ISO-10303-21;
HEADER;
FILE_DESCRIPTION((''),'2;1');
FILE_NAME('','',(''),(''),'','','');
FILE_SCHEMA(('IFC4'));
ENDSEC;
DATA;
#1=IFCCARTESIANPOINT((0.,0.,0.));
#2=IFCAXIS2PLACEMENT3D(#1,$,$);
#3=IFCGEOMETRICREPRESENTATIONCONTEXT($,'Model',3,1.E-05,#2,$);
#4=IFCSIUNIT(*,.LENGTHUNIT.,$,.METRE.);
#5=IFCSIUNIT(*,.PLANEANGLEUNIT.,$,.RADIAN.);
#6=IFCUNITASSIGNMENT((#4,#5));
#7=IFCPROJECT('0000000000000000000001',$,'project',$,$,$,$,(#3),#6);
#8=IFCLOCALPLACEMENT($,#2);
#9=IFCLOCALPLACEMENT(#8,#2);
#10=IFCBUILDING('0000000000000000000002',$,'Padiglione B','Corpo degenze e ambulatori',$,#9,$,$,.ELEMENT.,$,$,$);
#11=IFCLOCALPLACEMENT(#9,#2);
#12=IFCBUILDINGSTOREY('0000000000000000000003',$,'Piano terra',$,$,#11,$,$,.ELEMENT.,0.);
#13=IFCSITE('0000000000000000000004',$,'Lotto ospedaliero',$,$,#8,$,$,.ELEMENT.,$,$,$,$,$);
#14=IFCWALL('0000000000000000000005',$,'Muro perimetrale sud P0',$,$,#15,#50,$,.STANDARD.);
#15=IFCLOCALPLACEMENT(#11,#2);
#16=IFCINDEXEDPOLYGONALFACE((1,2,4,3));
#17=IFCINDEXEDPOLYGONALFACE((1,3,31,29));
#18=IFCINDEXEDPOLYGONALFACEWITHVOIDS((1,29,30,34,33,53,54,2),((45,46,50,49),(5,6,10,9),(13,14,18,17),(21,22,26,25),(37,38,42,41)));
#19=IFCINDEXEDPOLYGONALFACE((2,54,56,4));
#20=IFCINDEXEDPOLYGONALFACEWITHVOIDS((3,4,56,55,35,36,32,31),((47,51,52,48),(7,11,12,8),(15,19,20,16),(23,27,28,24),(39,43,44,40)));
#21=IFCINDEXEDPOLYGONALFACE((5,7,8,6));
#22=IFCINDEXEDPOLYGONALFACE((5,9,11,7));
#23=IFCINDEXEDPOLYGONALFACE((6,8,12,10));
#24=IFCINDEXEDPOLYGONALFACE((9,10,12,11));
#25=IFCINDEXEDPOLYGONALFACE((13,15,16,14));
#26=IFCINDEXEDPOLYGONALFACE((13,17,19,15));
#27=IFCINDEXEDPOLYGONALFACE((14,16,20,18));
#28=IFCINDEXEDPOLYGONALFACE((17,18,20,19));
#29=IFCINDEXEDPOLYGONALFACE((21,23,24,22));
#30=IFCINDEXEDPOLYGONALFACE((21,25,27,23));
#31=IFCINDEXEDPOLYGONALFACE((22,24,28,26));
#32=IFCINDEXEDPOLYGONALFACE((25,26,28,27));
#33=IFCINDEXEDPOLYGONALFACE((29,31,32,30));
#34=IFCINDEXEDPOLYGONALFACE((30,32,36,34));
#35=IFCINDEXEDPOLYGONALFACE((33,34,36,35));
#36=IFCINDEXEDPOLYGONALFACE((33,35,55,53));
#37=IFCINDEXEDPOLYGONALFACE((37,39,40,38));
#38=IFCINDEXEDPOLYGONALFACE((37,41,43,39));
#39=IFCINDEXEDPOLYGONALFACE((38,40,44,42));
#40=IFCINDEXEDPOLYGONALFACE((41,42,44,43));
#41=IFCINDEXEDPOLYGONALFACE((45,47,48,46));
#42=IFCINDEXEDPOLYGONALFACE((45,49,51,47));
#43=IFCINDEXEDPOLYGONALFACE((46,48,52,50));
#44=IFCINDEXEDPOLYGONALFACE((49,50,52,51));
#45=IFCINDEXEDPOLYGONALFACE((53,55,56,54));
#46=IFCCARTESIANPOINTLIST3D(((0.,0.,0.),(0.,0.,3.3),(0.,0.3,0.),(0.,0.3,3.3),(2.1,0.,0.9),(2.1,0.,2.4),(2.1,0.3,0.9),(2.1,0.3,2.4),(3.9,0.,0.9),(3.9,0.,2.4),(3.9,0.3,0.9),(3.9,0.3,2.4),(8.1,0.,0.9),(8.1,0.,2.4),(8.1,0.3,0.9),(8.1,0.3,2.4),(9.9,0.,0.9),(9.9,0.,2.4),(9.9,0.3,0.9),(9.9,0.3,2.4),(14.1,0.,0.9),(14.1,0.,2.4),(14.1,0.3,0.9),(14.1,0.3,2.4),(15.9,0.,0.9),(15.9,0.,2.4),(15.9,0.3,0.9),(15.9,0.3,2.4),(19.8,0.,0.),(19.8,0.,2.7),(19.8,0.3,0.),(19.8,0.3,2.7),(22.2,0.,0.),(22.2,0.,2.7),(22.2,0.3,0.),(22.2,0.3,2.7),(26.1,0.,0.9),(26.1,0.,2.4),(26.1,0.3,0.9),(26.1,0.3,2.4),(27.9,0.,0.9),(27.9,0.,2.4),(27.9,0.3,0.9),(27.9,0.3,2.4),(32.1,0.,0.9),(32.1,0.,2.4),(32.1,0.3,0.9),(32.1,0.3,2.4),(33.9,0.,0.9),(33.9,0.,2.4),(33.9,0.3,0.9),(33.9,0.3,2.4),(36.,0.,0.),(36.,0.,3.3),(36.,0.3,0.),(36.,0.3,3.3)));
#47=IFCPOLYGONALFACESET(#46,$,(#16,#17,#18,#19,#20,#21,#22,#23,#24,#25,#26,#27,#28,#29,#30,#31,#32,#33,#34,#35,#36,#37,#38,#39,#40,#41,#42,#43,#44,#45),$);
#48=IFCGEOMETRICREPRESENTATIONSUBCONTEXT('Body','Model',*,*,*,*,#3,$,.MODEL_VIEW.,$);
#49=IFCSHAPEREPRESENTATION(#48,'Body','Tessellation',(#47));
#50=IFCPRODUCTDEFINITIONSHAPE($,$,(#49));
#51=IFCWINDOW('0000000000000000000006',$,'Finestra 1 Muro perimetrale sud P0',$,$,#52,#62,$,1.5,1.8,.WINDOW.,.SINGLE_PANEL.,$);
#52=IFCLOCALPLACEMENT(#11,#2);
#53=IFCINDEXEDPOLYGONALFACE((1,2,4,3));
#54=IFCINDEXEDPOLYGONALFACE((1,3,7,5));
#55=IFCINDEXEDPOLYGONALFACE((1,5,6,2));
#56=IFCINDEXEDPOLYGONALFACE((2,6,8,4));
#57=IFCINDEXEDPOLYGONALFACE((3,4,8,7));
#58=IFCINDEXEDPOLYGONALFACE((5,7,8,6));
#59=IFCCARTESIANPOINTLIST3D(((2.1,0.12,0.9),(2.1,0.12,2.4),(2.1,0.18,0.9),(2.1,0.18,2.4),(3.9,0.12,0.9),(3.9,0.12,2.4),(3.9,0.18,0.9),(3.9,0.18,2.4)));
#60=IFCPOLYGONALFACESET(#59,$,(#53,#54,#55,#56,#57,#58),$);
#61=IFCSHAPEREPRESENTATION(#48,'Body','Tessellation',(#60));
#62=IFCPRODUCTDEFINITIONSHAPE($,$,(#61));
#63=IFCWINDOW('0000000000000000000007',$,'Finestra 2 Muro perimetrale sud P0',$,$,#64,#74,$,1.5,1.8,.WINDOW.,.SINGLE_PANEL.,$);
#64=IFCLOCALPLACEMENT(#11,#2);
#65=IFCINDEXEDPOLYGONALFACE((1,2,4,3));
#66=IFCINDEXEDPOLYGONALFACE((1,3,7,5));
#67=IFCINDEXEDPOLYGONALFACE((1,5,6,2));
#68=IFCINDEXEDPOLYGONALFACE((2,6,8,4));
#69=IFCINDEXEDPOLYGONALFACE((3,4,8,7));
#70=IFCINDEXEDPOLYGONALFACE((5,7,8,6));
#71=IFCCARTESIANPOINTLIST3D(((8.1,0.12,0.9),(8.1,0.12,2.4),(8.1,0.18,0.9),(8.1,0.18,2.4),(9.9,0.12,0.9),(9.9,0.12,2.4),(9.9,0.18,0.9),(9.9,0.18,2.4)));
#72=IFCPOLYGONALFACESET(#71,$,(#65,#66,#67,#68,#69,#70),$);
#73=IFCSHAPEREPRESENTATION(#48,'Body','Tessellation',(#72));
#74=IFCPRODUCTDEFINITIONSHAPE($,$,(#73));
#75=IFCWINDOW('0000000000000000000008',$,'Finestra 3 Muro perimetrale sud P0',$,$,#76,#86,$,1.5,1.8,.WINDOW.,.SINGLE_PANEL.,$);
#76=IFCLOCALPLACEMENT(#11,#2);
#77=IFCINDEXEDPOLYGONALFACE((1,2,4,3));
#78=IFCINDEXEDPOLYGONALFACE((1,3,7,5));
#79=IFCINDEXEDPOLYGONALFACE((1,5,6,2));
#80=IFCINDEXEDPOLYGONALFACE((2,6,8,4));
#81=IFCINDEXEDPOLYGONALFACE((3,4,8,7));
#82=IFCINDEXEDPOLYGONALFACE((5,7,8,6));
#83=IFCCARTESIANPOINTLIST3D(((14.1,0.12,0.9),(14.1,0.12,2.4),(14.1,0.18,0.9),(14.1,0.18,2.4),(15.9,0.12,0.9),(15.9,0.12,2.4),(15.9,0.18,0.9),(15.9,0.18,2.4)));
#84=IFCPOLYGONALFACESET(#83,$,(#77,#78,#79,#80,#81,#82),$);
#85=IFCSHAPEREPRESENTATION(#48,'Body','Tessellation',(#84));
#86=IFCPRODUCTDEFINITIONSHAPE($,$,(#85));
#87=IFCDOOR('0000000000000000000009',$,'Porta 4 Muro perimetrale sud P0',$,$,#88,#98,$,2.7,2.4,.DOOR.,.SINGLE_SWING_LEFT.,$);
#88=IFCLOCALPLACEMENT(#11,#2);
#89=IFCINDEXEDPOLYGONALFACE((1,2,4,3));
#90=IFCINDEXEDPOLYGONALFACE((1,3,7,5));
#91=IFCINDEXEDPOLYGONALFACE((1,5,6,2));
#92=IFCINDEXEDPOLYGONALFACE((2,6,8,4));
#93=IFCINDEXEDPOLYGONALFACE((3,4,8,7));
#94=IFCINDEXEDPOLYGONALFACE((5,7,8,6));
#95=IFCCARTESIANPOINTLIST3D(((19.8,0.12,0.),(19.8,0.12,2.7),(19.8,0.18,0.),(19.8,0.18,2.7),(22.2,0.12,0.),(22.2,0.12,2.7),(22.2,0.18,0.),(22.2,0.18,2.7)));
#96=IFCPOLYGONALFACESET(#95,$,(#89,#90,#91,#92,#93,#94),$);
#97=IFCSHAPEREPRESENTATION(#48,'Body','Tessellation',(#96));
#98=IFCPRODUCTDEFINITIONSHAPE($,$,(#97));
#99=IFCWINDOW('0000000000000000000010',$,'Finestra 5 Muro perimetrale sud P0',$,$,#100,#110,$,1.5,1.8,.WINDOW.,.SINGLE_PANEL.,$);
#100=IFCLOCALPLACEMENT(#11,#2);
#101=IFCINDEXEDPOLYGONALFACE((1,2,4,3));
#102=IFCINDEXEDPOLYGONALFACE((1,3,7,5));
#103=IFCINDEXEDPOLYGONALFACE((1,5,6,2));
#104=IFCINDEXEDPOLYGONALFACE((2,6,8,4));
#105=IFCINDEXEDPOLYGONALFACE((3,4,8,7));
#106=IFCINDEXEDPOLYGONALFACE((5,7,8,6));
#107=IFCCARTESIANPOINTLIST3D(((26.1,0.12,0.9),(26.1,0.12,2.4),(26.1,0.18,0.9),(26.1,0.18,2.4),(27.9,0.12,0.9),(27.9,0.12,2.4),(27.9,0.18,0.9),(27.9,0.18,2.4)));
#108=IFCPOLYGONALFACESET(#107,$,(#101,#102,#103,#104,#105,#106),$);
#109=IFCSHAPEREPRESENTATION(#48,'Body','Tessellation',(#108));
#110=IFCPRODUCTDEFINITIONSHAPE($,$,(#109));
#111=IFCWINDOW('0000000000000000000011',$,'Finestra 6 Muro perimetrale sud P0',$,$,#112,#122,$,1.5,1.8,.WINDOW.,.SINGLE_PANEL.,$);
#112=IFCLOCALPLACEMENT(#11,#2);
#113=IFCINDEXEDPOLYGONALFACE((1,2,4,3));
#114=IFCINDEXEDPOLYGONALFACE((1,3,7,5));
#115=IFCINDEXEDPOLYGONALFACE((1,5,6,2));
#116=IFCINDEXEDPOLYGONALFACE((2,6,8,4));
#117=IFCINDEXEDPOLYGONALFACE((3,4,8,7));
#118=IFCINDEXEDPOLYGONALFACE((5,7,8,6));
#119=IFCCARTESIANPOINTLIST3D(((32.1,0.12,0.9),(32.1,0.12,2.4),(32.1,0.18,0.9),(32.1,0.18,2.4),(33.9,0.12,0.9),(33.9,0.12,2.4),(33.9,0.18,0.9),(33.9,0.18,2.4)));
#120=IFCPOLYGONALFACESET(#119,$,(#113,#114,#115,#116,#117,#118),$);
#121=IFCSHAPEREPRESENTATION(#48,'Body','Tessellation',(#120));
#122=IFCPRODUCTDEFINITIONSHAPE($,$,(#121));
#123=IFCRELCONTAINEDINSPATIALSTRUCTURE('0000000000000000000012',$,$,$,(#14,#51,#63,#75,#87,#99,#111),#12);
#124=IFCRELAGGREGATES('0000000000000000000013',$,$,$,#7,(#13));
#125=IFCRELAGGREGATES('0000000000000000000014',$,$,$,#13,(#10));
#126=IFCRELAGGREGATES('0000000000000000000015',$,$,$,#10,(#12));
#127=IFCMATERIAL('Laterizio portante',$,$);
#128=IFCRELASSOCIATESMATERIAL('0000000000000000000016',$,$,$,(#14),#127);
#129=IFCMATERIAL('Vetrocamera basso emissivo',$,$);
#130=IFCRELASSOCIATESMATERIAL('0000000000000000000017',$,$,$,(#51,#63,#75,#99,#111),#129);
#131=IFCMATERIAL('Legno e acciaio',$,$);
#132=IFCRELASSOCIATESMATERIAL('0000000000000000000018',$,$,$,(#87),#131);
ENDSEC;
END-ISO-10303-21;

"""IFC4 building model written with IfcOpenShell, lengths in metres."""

from ifc_helpers import new_model, si_unit, frame, frame_2d, origin, place, context, subcontext, project, spatial, rectangle, extrude, material, element, fill, save


model = new_model("IFC4")

# Units and contexts
model_context = context("Model", 3, precision=1e-05, world=origin())
body_context = subcontext(model_context, "Body", "Model", "MODEL_VIEW")
ifc_project = project(units=[si_unit("LENGTHUNIT", "METRE"), si_unit("PLANEANGLEUNIT", "RADIAN")], contexts=[model_context])

# Site, building, storey
site_placement = place(None, origin())
site = spatial("IfcSite", under=ifc_project, at=site_placement, Name="Lotto ospedaliero", CompositionType="ELEMENT")
building_placement = place(site_placement, origin())
building = spatial("IfcBuilding", under=site, at=building_placement, Name="Padiglione B", Description="Corpo degenze e ambulatori", CompositionType="ELEMENT")
storey_placement = place(building_placement, origin())
storey = spatial("IfcBuildingStorey", under=building, at=storey_placement, Name="Piano terra", CompositionType="ELEMENT", Elevation=0.0)

# Wall, openings, windows, door
ifc_material_1 = material(Name="Laterizio portante")
wall_1_placement = place(storey_placement, origin())
wall_1 = element("IfcWall", 1, at=wall_1_placement, inside=storey, material=ifc_material_1, Name="Muro perimetrale sud P0", PredefinedType="STANDARD", context=body_context, shape_type="SweptSolid", body=[
    extrude(rectangle(XDim=36.0, YDim=0.3, at=frame_2d((18.0, 0.15))), origin(), (0.0, 0.0, 1.0), 3.3),
])
opening_1_placement = place(wall_1_placement, frame((2.1, -0.1, 0.9)))
opening_1 = element("IfcOpeningElement", 2, at=opening_1_placement, cuts=wall_1, PredefinedType="OPENING", context=body_context, shape_type="SweptSolid", body=[
    extrude(rectangle(XDim=1.8, YDim=0.5, at=frame_2d((0.9, 0.25))), origin(), (0.0, 0.0, 1.0), 1.5),
])
opening_2_placement = place(wall_1_placement, frame((8.1, -0.1, 0.9)))
opening_2 = element("IfcOpeningElement", 3, at=opening_2_placement, cuts=wall_1, PredefinedType="OPENING", context=body_context, shape_type="SweptSolid", body=[
    extrude(rectangle(XDim=1.8, YDim=0.5, at=frame_2d((0.9, 0.25))), origin(), (0.0, 0.0, 1.0), 1.5),
])
opening_3_placement = place(wall_1_placement, frame((14.1, -0.1, 0.9)))
opening_3 = element("IfcOpeningElement", 4, at=opening_3_placement, cuts=wall_1, PredefinedType="OPENING", context=body_context, shape_type="SweptSolid", body=[
    extrude(rectangle(XDim=1.8, YDim=0.5, at=frame_2d((0.9, 0.25))), origin(), (0.0, 0.0, 1.0), 1.5),
])
opening_4_placement = place(wall_1_placement, frame((19.8, -0.1, 0.0)))
opening_4 = element("IfcOpeningElement", 5, at=opening_4_placement, cuts=wall_1, PredefinedType="OPENING", context=body_context, shape_type="SweptSolid", body=[
    extrude(rectangle(XDim=2.4, YDim=0.5, at=frame_2d((1.2, 0.25))), origin(), (0.0, 0.0, 1.0), 2.7),
])
opening_5_placement = place(wall_1_placement, frame((26.1, -0.1, 0.9)))
opening_5 = element("IfcOpeningElement", 6, at=opening_5_placement, cuts=wall_1, PredefinedType="OPENING", context=body_context, shape_type="SweptSolid", body=[
    extrude(rectangle(XDim=1.8, YDim=0.5, at=frame_2d((0.9, 0.25))), origin(), (0.0, 0.0, 1.0), 1.5),
])
opening_6_placement = place(wall_1_placement, frame((32.1, -0.1, 0.9)))
opening_6 = element("IfcOpeningElement", 7, at=opening_6_placement, cuts=wall_1, PredefinedType="OPENING", context=body_context, shape_type="SweptSolid", body=[
    extrude(rectangle(XDim=1.8, YDim=0.5, at=frame_2d((0.9, 0.25))), origin(), (0.0, 0.0, 1.0), 1.5),
])
ifc_material_2 = material(Name="Vetrocamera basso emissivo")
window_1_placement = place(wall_1_placement, frame((2.1, 0.12, 0.9)))
window_1 = element("IfcWindow", 8, at=window_1_placement, inside=storey, material=ifc_material_2, Name="Finestra 1 Muro perimetrale sud P0", OverallHeight=1.5, OverallWidth=1.8, PartitioningType="SINGLE_PANEL", PredefinedType="WINDOW", context=body_context, shape_type="SweptSolid", body=[
    extrude(rectangle(XDim=1.8, YDim=0.06, at=frame_2d((0.9, 0.03))), origin(), (0.0, 0.0, 1.0), 1.5),
])
fill(opening_1, window_1)
window_2_placement = place(wall_1_placement, frame((8.1, 0.12, 0.9)))
window_2 = element("IfcWindow", 9, at=window_2_placement, inside=storey, material=ifc_material_2, Name="Finestra 2 Muro perimetrale sud P0", OverallHeight=1.5, OverallWidth=1.8, PartitioningType="SINGLE_PANEL", PredefinedType="WINDOW", context=body_context, shape_type="SweptSolid", body=[
    extrude(rectangle(XDim=1.8, YDim=0.06, at=frame_2d((0.9, 0.03))), origin(), (0.0, 0.0, 1.0), 1.5),
])
fill(opening_2, window_2)
window_3_placement = place(wall_1_placement, frame((14.1, 0.12, 0.9)))
window_3 = element("IfcWindow", 10, at=window_3_placement, inside=storey, material=ifc_material_2, Name="Finestra 3 Muro perimetrale sud P0", OverallHeight=1.5, OverallWidth=1.8, PartitioningType="SINGLE_PANEL", PredefinedType="WINDOW", context=body_context, shape_type="SweptSolid", body=[
    extrude(rectangle(XDim=1.8, YDim=0.06, at=frame_2d((0.9, 0.03))), origin(), (0.0, 0.0, 1.0), 1.5),
])
fill(opening_3, window_3)
ifc_material_3 = material(Name="Legno e acciaio")
door_placement = place(wall_1_placement, frame((19.8, 0.12, 0.0)))
door = element("IfcDoor", 11, at=door_placement, inside=storey, material=ifc_material_3, Name="Porta 4 Muro perimetrale sud P0", OperationType="SINGLE_SWING_LEFT", OverallHeight=2.7, OverallWidth=2.4, PredefinedType="DOOR", context=body_context, shape_type="SweptSolid", body=[
    extrude(rectangle(XDim=2.4, YDim=0.06, at=frame_2d((1.2, 0.03))), origin(), (0.0, 0.0, 1.0), 2.7),
])
fill(opening_4, door)
window_4_placement = place(wall_1_placement, frame((26.1, 0.12, 0.9)))
window_4 = element("IfcWindow", 12, at=window_4_placement, inside=storey, material=ifc_material_2, Name="Finestra 5 Muro perimetrale sud P0", OverallHeight=1.5, OverallWidth=1.8, PartitioningType="SINGLE_PANEL", PredefinedType="WINDOW", context=body_context, shape_type="SweptSolid", body=[
    extrude(rectangle(XDim=1.8, YDim=0.06, at=frame_2d((0.9, 0.03))), origin(), (0.0, 0.0, 1.0), 1.5),
])
fill(opening_5, window_4)
window_5_placement = place(wall_1_placement, frame((32.1, 0.12, 0.9)))
window_5 = element("IfcWindow", 13, at=window_5_placement, inside=storey, material=ifc_material_2, Name="Finestra 6 Muro perimetrale sud P0", OverallHeight=1.5, OverallWidth=1.8, PartitioningType="SINGLE_PANEL", PredefinedType="WINDOW", context=body_context, shape_type="SweptSolid", body=[
    extrude(rectangle(XDim=1.8, YDim=0.06, at=frame_2d((0.9, 0.03))), origin(), (0.0, 0.0, 1.0), 1.5),
])
fill(opening_6, window_5)

save(model, "model.ifc")
